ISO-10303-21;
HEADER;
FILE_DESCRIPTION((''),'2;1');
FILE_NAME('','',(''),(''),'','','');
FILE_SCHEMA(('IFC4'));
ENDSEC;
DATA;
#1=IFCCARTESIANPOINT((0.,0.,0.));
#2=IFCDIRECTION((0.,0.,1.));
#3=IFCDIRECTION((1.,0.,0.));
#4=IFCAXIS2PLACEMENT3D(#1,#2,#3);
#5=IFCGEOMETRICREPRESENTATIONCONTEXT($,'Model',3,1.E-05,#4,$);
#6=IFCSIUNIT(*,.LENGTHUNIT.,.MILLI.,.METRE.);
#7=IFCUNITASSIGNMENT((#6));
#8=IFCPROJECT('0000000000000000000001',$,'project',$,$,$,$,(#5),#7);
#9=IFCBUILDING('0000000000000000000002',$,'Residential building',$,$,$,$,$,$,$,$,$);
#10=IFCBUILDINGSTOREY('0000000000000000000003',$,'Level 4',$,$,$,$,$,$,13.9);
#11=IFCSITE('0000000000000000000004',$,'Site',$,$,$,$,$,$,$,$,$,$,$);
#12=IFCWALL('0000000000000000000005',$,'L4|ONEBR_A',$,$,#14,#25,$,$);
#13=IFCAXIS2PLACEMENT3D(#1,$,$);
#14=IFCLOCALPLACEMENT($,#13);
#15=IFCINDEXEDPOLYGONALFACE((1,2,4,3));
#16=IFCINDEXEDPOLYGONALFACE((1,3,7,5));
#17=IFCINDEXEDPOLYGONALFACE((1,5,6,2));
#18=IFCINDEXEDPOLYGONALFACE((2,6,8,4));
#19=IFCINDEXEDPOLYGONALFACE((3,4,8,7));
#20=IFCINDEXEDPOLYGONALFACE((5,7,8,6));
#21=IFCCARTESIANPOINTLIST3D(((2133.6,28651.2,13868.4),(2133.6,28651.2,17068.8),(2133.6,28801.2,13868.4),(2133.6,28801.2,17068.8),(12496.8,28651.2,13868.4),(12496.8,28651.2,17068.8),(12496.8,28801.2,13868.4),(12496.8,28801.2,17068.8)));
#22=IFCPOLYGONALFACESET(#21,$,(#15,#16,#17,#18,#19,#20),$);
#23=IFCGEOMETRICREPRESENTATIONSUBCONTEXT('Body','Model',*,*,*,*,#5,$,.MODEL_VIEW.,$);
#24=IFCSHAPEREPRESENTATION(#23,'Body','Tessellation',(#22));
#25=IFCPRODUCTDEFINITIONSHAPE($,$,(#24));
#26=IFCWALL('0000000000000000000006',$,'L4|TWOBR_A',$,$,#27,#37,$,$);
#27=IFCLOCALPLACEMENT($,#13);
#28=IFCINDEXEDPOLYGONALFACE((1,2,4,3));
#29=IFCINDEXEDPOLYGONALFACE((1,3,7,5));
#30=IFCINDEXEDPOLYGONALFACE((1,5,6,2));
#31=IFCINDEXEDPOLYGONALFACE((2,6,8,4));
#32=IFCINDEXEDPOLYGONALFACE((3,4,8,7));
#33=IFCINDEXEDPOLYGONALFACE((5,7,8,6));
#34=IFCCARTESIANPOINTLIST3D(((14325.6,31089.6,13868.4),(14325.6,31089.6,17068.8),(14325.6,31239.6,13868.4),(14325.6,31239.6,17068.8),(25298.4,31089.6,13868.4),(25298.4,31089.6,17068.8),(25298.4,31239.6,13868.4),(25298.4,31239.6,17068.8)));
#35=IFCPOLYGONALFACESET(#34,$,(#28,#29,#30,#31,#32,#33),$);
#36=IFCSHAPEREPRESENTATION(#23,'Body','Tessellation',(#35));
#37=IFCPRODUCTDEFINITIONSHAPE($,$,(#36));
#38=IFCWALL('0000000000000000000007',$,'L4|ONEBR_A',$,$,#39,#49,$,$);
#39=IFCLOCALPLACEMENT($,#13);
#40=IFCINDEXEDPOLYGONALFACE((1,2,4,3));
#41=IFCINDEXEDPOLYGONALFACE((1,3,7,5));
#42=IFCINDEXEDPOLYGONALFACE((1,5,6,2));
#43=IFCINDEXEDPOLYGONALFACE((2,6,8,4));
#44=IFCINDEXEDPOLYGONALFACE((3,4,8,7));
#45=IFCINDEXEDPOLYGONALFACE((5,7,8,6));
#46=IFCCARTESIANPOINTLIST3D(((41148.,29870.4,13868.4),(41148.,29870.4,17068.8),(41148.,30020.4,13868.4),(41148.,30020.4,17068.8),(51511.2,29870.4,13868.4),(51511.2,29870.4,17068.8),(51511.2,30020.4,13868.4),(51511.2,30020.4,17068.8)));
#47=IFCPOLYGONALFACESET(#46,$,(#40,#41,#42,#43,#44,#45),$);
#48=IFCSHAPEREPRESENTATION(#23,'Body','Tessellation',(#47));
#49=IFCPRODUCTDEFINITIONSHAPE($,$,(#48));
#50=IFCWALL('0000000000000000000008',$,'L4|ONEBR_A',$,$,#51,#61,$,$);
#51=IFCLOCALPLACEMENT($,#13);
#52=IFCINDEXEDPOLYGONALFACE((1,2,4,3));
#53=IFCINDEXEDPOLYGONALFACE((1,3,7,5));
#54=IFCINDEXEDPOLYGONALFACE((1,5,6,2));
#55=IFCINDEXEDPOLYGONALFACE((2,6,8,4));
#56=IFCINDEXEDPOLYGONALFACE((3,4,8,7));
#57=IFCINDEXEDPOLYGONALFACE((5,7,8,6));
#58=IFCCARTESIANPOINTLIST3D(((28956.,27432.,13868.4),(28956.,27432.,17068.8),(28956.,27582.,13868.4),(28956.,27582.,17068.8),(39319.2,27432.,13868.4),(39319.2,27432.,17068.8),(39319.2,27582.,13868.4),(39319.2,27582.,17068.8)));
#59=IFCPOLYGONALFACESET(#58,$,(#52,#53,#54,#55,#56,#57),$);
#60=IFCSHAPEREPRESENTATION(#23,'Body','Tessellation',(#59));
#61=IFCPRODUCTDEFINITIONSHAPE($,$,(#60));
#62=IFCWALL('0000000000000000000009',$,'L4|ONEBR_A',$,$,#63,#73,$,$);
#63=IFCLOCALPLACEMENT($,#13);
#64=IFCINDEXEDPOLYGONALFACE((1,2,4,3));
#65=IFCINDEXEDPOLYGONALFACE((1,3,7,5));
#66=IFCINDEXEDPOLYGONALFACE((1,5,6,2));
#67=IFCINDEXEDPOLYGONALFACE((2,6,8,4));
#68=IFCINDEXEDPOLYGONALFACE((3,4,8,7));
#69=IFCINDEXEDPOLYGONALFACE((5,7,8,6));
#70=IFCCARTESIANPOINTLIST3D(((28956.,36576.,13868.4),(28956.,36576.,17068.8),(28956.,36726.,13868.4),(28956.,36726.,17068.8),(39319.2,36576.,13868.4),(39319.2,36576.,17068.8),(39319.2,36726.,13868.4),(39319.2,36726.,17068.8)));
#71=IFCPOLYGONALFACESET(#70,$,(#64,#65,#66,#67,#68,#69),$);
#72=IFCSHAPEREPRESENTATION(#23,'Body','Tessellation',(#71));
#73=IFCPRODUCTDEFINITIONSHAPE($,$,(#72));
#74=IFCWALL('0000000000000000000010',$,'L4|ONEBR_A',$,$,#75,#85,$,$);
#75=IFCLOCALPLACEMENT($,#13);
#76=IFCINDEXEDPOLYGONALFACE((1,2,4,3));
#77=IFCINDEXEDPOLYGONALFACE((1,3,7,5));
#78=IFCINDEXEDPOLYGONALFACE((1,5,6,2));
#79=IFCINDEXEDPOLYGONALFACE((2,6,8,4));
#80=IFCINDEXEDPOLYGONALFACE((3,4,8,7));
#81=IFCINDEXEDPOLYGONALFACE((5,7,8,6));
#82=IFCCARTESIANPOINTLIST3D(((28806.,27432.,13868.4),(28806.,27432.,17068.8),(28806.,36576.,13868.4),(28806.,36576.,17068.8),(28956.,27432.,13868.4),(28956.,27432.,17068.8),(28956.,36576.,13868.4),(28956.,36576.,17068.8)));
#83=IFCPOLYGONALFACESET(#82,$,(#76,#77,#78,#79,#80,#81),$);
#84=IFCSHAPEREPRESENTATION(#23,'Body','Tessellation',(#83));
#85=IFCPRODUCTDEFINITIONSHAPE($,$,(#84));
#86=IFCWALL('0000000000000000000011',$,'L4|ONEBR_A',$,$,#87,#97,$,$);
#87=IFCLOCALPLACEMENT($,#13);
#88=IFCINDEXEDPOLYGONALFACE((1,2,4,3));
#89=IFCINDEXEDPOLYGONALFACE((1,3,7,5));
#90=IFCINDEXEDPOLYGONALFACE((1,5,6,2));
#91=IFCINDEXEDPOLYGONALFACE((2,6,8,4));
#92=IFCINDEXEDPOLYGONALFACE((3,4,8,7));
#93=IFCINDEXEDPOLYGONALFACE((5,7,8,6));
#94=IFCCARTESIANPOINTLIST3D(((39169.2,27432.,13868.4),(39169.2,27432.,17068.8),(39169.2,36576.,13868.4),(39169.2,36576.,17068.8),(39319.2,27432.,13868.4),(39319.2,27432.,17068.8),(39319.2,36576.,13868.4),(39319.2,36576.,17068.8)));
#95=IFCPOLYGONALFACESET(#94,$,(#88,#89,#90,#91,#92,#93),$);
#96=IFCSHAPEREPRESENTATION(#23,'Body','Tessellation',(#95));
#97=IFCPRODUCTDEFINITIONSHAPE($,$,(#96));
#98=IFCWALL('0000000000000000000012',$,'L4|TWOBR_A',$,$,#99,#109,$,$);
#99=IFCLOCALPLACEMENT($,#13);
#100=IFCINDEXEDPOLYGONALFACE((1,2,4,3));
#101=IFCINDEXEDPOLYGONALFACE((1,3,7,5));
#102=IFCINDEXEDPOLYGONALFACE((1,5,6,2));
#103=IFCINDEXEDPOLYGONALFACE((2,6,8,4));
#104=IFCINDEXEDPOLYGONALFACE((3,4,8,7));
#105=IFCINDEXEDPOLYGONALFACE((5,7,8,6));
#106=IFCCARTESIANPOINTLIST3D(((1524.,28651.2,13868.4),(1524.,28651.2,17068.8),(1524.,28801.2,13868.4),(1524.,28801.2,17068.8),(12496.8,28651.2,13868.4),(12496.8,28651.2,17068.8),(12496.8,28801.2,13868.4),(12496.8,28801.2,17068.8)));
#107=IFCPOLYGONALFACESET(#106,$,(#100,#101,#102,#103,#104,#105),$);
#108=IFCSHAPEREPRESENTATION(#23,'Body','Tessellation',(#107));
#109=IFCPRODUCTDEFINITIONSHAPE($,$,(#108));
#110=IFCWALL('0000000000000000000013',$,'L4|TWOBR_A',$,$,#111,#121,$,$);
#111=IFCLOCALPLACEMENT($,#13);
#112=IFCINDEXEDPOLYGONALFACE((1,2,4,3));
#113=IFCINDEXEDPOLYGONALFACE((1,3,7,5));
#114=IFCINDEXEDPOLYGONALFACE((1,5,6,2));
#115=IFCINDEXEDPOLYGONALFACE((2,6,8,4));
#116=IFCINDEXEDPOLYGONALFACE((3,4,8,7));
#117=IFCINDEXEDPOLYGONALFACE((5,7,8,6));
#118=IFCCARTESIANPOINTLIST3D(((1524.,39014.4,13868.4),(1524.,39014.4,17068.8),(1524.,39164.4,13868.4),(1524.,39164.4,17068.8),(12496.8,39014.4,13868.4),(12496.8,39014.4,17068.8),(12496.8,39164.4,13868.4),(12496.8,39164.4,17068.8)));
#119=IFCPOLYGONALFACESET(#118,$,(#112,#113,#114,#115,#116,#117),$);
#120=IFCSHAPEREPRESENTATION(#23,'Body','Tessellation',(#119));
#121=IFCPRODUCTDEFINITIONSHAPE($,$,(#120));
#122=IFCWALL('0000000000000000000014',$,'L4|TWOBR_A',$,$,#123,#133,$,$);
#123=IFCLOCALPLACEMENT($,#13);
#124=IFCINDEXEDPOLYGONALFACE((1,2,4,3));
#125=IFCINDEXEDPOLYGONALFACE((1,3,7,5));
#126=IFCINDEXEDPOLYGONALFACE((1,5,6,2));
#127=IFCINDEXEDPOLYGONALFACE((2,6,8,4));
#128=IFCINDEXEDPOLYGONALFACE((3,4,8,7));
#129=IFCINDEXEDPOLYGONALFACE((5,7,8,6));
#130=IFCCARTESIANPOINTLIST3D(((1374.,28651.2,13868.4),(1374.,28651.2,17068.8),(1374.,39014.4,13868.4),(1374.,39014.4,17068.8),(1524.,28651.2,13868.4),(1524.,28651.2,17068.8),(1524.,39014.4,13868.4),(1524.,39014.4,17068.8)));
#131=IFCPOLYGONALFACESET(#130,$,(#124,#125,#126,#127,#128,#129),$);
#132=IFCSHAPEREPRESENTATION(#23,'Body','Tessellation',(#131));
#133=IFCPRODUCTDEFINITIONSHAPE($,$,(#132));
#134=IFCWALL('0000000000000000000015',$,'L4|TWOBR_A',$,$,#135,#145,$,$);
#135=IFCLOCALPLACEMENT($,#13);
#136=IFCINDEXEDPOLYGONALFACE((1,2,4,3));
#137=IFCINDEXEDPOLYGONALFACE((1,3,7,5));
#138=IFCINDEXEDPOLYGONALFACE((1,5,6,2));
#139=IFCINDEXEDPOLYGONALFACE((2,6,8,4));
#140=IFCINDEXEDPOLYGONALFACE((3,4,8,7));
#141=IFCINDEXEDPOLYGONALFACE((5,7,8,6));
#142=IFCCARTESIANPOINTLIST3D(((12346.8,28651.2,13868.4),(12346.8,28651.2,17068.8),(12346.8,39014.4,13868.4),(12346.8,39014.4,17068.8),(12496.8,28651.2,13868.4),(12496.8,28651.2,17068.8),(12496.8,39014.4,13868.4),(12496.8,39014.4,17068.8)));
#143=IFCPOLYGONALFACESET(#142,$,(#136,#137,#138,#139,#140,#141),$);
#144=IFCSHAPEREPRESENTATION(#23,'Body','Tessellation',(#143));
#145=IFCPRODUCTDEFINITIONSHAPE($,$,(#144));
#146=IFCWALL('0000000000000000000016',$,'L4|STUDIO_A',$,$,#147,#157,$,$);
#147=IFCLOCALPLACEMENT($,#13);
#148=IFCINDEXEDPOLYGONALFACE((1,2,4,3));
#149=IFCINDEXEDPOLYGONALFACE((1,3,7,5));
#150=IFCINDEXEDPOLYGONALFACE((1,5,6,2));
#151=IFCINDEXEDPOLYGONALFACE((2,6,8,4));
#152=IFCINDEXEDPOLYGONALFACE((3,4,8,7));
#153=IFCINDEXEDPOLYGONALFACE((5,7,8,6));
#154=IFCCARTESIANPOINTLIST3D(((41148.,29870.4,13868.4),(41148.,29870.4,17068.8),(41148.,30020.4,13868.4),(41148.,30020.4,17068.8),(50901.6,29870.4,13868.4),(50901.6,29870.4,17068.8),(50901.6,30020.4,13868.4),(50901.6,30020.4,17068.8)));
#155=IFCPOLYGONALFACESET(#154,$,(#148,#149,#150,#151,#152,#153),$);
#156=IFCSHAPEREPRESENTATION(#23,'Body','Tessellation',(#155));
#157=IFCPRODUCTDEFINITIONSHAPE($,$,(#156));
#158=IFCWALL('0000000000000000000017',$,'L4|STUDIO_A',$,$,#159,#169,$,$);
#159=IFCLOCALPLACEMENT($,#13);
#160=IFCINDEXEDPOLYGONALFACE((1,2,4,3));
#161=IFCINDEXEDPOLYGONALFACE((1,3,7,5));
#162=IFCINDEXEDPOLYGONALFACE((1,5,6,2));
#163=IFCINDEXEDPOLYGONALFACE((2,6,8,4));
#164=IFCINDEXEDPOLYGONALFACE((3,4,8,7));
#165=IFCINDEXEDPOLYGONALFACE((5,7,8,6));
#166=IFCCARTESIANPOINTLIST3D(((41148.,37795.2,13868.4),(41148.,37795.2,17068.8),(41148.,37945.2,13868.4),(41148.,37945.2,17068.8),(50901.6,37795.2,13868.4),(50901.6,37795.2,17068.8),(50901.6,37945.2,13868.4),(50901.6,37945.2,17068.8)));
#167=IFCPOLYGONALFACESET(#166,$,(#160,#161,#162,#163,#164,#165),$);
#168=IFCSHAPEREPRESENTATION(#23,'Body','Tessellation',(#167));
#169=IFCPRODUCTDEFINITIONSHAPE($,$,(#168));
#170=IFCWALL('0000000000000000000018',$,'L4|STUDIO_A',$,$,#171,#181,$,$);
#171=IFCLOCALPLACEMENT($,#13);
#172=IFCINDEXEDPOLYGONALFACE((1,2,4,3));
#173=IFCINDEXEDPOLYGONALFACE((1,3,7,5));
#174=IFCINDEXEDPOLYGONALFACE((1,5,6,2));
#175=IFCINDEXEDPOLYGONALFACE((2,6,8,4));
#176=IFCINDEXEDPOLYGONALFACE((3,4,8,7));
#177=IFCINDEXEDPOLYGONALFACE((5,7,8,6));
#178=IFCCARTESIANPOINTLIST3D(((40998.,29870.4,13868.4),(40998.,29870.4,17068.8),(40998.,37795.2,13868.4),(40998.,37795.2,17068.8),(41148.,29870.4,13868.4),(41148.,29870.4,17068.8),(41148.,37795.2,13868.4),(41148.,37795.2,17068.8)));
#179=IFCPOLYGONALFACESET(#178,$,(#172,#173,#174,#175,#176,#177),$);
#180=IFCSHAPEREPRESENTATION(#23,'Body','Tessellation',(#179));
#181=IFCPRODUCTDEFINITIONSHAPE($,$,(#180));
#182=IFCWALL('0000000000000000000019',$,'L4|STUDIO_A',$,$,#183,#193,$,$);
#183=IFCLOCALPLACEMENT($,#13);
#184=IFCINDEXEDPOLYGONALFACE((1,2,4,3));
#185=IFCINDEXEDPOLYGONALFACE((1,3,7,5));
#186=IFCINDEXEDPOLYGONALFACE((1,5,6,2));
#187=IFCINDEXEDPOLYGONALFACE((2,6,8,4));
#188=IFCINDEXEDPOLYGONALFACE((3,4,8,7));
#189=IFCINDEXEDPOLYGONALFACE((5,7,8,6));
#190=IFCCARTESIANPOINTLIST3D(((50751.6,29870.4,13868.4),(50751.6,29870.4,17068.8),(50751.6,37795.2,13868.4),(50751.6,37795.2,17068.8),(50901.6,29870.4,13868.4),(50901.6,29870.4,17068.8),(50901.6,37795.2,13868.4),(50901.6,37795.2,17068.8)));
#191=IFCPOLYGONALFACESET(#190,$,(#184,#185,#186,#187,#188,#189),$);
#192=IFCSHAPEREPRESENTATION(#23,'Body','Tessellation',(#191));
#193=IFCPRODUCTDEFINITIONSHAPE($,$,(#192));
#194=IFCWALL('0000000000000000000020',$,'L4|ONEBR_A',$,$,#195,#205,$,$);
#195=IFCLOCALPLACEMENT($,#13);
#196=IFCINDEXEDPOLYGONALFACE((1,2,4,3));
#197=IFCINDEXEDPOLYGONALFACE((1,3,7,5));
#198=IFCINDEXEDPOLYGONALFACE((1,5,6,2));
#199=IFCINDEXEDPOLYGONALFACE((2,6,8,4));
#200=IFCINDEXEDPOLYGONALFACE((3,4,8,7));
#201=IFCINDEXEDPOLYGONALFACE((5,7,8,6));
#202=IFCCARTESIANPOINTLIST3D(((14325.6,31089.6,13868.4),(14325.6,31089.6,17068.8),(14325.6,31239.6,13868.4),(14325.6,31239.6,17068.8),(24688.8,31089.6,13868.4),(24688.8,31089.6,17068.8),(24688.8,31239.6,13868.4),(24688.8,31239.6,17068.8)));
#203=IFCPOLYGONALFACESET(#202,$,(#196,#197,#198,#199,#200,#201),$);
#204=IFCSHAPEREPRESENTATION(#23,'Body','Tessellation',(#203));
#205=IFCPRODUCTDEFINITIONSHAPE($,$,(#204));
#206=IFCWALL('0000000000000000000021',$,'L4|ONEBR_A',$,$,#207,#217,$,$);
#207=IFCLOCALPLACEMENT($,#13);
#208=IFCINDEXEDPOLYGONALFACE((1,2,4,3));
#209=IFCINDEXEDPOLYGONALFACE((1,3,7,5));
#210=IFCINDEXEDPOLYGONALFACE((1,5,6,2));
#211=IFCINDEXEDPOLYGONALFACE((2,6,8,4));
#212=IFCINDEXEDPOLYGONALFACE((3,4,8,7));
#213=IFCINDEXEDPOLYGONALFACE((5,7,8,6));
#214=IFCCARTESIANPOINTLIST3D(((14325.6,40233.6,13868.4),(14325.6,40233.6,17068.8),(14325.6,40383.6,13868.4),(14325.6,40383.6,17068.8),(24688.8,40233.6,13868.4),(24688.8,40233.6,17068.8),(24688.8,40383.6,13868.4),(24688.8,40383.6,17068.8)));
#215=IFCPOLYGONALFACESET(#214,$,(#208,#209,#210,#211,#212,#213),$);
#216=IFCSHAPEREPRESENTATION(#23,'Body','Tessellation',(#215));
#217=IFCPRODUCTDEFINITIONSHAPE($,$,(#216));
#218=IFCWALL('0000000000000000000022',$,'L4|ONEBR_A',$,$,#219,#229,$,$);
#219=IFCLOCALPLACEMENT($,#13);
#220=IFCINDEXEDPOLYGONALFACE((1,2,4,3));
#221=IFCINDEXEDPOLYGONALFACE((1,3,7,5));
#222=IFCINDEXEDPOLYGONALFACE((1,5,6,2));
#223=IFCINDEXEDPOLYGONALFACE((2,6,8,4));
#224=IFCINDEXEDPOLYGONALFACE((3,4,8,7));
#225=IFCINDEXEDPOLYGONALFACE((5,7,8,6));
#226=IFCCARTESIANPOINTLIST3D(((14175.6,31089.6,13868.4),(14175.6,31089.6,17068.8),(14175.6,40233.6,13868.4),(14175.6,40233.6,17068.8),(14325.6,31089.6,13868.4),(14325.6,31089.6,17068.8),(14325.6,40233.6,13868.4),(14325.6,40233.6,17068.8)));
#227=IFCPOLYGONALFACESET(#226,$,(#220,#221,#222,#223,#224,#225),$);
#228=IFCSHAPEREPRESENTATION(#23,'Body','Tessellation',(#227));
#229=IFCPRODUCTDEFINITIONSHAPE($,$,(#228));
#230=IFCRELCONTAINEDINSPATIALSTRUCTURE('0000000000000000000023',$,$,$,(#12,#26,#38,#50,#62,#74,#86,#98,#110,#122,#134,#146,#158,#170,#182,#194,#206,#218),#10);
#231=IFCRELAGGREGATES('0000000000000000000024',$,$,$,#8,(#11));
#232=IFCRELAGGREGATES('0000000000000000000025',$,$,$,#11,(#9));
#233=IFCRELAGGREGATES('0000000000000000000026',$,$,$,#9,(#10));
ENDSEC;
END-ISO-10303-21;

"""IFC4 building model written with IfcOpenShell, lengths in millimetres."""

from ifc_helpers import new_model, si_unit, frame, origin_with_axes, place, context, subcontext, project, spatial, indexed_curve, outline, extrude, element, save


model = new_model("IFC4")

# Units and contexts
model_context = context("Model", 3, precision=1e-05, world=origin_with_axes())
body_context = subcontext(model_context, "Body", "Model", "MODEL_VIEW")
ifc_project = project(units=[si_unit("LENGTHUNIT", "METRE", prefix="MILLI")], contexts=[model_context])

# Site, building, storey
site = spatial("IfcSite", under=ifc_project, Name="Site")
building = spatial("IfcBuilding", under=site, Name="Residential building")
storey = spatial("IfcBuildingStorey", under=building, Name="Level 4", Elevation=13.9)

# Walls
wall_1_placement = place(None, frame((2133.6, 28651.2, 13868.4), z_axis=(0.0, 0.0, 1.0), x_axis=(1.0, 0.0, 0.0)))
element("IfcWall", 1, at=wall_1_placement, inside=storey, Name="L4|ONEBR_A", context=body_context, shape_type="SweptSolid", body=[
    extrude(outline(indexed_curve([(0.0, 0.0), (0.0, 150.0), (10363.2, 150.0), (10363.2, 0.0), (0.0, 0.0)], self_intersect=False)), origin_with_axes(), (0.0, 0.0, 1.0), 3200.4),
])
wall_2_placement = place(None, frame((14325.6, 31089.6, 13868.4), z_axis=(0.0, 0.0, 1.0), x_axis=(1.0, 0.0, 0.0)))
element("IfcWall", 2, at=wall_2_placement, inside=storey, Name="L4|TWOBR_A", context=body_context, shape_type="SweptSolid", body=[
    extrude(outline(indexed_curve([(0.0, 0.0), (0.0, 150.0), (10972.8, 150.0), (10972.8, 0.0), (0.0, 0.0)], self_intersect=False)), origin_with_axes(), (0.0, 0.0, 1.0), 3200.4),
])
for number, where, z_axis, x_axis, name in (
    (3, (41148.0, 29870.4, 13868.4), (0.0, 0.0, 1.0), (1.0, 0.0, 0.0), "L4|ONEBR_A"),
    (4, (28956.0, 27432.0, 13868.4), (0.0, 0.0, 1.0), (1.0, 0.0, 0.0), "L4|ONEBR_A"),
    (5, (28956.0, 36576.0, 13868.4), (0.0, 0.0, 1.0), (1.0, 0.0, 0.0), "L4|ONEBR_A"),
):
    element("IfcWall", number, at=place(None, frame(where, z_axis=z_axis, x_axis=x_axis)), inside=storey, Name=name, context=body_context, shape_type="SweptSolid", body=[
        extrude(outline(indexed_curve([(0.0, 0.0), (0.0, 150.0), (10363.2, 150.0), (10363.2, 0.0), (0.0, 0.0)], self_intersect=False)), origin_with_axes(), (0.0, 0.0, 1.0), 3200.4),
    ])
for number, where, z_axis, x_axis, name in (
    (6, (28956.0, 27432.0, 13868.4), (0.0, 0.0, 1.0), (0.0, 1.0, 0.0), "L4|ONEBR_A"),
    (7, (39319.2, 27432.0, 13868.4), (0.0, 0.0, 1.0), (0.0, 1.0, 0.0), "L4|ONEBR_A"),
):
    element("IfcWall", number, at=place(None, frame(where, z_axis=z_axis, x_axis=x_axis)), inside=storey, Name=name, context=body_context, shape_type="SweptSolid", body=[
        extrude(outline(indexed_curve([(0.0, 0.0), (0.0, 150.0), (9144.0, 150.0), (9144.0, 0.0), (0.0, 0.0)], self_intersect=False)), origin_with_axes(), (0.0, 0.0, 1.0), 3200.4),
    ])
for number, where, z_axis, x_axis, name in (
    (8, (1524.0, 28651.2, 13868.4), (0.0, 0.0, 1.0), (1.0, 0.0, 0.0), "L4|TWOBR_A"),
    (9, (1524.0, 39014.4, 13868.4), (0.0, 0.0, 1.0), (1.0, 0.0, 0.0), "L4|TWOBR_A"),
):
    element("IfcWall", number, at=place(None, frame(where, z_axis=z_axis, x_axis=x_axis)), inside=storey, Name=name, context=body_context, shape_type="SweptSolid", body=[
        extrude(outline(indexed_curve([(0.0, 0.0), (0.0, 150.0), (10972.8, 150.0), (10972.8, 0.0), (0.0, 0.0)], self_intersect=False)), origin_with_axes(), (0.0, 0.0, 1.0), 3200.4),
    ])
for number, where, z_axis, x_axis, name in (
    (10, (1524.0, 28651.2, 13868.4), (0.0, 0.0, 1.0), (0.0, 1.0, 0.0), "L4|TWOBR_A"),
    (11, (12496.8, 28651.2, 13868.4), (0.0, 0.0, 1.0), (0.0, 1.0, 0.0), "L4|TWOBR_A"),
):
    element("IfcWall", number, at=place(None, frame(where, z_axis=z_axis, x_axis=x_axis)), inside=storey, Name=name, context=body_context, shape_type="SweptSolid", body=[
        extrude(outline(indexed_curve([(0.0, 0.0), (0.0, 150.0), (10363.2, 150.0), (10363.2, 0.0), (0.0, 0.0)], self_intersect=False)), origin_with_axes(), (0.0, 0.0, 1.0), 3200.4),
    ])
for number, where, z_axis, x_axis, name in (
    (12, (41148.0, 29870.4, 13868.4), (0.0, 0.0, 1.0), (1.0, 0.0, 0.0), "L4|STUDIO_A"),
    (13, (41148.0, 37795.2, 13868.4), (0.0, 0.0, 1.0), (1.0, 0.0, 0.0), "L4|STUDIO_A"),
):
    element("IfcWall", number, at=place(None, frame(where, z_axis=z_axis, x_axis=x_axis)), inside=storey, Name=name, context=body_context, shape_type="SweptSolid", body=[
        extrude(outline(indexed_curve([(0.0, 0.0), (0.0, 150.0), (9753.6, 150.0), (9753.6, 0.0), (0.0, 0.0)], self_intersect=False)), origin_with_axes(), (0.0, 0.0, 1.0), 3200.4),
    ])
for number, where, z_axis, x_axis, name in (
    (14, (41148.0, 29870.4, 13868.4), (0.0, 0.0, 1.0), (0.0, 1.0, 0.0), "L4|STUDIO_A"),
    (15, (50901.6, 29870.4, 13868.4), (0.0, 0.0, 1.0), (0.0, 1.0, 0.0), "L4|STUDIO_A"),
):
    element("IfcWall", number, at=place(None, frame(where, z_axis=z_axis, x_axis=x_axis)), inside=storey, Name=name, context=body_context, shape_type="SweptSolid", body=[
        extrude(outline(indexed_curve([(0.0, 0.0), (0.0, 150.0), (7924.8, 150.0), (7924.8, 0.0), (0.0, 0.0)], self_intersect=False)), origin_with_axes(), (0.0, 0.0, 1.0), 3200.4),
    ])
for number, where, z_axis, x_axis, name in (
    (16, (14325.6, 31089.6, 13868.4), (0.0, 0.0, 1.0), (1.0, 0.0, 0.0), "L4|ONEBR_A"),
    (17, (14325.6, 40233.6, 13868.4), (0.0, 0.0, 1.0), (1.0, 0.0, 0.0), "L4|ONEBR_A"),
):
    element("IfcWall", number, at=place(None, frame(where, z_axis=z_axis, x_axis=x_axis)), inside=storey, Name=name, context=body_context, shape_type="SweptSolid", body=[
        extrude(outline(indexed_curve([(0.0, 0.0), (0.0, 150.0), (10363.2, 150.0), (10363.2, 0.0), (0.0, 0.0)], self_intersect=False)), origin_with_axes(), (0.0, 0.0, 1.0), 3200.4),
    ])
for number, where, z_axis, x_axis, name in (
    (18, (14325.6, 31089.6, 13868.4), (0.0, 0.0, 1.0), (0.0, 1.0, 0.0), "L4|ONEBR_A"),
):
    element("IfcWall", number, at=place(None, frame(where, z_axis=z_axis, x_axis=x_axis)), inside=storey, Name=name, context=body_context, shape_type="SweptSolid", body=[
        extrude(outline(indexed_curve([(0.0, 0.0), (0.0, 150.0), (9144.0, 150.0), (9144.0, 0.0), (0.0, 0.0)], self_intersect=False)), origin_with_axes(), (0.0, 0.0, 1.0), 3200.4),
    ])

save(model, "model.ifc")
